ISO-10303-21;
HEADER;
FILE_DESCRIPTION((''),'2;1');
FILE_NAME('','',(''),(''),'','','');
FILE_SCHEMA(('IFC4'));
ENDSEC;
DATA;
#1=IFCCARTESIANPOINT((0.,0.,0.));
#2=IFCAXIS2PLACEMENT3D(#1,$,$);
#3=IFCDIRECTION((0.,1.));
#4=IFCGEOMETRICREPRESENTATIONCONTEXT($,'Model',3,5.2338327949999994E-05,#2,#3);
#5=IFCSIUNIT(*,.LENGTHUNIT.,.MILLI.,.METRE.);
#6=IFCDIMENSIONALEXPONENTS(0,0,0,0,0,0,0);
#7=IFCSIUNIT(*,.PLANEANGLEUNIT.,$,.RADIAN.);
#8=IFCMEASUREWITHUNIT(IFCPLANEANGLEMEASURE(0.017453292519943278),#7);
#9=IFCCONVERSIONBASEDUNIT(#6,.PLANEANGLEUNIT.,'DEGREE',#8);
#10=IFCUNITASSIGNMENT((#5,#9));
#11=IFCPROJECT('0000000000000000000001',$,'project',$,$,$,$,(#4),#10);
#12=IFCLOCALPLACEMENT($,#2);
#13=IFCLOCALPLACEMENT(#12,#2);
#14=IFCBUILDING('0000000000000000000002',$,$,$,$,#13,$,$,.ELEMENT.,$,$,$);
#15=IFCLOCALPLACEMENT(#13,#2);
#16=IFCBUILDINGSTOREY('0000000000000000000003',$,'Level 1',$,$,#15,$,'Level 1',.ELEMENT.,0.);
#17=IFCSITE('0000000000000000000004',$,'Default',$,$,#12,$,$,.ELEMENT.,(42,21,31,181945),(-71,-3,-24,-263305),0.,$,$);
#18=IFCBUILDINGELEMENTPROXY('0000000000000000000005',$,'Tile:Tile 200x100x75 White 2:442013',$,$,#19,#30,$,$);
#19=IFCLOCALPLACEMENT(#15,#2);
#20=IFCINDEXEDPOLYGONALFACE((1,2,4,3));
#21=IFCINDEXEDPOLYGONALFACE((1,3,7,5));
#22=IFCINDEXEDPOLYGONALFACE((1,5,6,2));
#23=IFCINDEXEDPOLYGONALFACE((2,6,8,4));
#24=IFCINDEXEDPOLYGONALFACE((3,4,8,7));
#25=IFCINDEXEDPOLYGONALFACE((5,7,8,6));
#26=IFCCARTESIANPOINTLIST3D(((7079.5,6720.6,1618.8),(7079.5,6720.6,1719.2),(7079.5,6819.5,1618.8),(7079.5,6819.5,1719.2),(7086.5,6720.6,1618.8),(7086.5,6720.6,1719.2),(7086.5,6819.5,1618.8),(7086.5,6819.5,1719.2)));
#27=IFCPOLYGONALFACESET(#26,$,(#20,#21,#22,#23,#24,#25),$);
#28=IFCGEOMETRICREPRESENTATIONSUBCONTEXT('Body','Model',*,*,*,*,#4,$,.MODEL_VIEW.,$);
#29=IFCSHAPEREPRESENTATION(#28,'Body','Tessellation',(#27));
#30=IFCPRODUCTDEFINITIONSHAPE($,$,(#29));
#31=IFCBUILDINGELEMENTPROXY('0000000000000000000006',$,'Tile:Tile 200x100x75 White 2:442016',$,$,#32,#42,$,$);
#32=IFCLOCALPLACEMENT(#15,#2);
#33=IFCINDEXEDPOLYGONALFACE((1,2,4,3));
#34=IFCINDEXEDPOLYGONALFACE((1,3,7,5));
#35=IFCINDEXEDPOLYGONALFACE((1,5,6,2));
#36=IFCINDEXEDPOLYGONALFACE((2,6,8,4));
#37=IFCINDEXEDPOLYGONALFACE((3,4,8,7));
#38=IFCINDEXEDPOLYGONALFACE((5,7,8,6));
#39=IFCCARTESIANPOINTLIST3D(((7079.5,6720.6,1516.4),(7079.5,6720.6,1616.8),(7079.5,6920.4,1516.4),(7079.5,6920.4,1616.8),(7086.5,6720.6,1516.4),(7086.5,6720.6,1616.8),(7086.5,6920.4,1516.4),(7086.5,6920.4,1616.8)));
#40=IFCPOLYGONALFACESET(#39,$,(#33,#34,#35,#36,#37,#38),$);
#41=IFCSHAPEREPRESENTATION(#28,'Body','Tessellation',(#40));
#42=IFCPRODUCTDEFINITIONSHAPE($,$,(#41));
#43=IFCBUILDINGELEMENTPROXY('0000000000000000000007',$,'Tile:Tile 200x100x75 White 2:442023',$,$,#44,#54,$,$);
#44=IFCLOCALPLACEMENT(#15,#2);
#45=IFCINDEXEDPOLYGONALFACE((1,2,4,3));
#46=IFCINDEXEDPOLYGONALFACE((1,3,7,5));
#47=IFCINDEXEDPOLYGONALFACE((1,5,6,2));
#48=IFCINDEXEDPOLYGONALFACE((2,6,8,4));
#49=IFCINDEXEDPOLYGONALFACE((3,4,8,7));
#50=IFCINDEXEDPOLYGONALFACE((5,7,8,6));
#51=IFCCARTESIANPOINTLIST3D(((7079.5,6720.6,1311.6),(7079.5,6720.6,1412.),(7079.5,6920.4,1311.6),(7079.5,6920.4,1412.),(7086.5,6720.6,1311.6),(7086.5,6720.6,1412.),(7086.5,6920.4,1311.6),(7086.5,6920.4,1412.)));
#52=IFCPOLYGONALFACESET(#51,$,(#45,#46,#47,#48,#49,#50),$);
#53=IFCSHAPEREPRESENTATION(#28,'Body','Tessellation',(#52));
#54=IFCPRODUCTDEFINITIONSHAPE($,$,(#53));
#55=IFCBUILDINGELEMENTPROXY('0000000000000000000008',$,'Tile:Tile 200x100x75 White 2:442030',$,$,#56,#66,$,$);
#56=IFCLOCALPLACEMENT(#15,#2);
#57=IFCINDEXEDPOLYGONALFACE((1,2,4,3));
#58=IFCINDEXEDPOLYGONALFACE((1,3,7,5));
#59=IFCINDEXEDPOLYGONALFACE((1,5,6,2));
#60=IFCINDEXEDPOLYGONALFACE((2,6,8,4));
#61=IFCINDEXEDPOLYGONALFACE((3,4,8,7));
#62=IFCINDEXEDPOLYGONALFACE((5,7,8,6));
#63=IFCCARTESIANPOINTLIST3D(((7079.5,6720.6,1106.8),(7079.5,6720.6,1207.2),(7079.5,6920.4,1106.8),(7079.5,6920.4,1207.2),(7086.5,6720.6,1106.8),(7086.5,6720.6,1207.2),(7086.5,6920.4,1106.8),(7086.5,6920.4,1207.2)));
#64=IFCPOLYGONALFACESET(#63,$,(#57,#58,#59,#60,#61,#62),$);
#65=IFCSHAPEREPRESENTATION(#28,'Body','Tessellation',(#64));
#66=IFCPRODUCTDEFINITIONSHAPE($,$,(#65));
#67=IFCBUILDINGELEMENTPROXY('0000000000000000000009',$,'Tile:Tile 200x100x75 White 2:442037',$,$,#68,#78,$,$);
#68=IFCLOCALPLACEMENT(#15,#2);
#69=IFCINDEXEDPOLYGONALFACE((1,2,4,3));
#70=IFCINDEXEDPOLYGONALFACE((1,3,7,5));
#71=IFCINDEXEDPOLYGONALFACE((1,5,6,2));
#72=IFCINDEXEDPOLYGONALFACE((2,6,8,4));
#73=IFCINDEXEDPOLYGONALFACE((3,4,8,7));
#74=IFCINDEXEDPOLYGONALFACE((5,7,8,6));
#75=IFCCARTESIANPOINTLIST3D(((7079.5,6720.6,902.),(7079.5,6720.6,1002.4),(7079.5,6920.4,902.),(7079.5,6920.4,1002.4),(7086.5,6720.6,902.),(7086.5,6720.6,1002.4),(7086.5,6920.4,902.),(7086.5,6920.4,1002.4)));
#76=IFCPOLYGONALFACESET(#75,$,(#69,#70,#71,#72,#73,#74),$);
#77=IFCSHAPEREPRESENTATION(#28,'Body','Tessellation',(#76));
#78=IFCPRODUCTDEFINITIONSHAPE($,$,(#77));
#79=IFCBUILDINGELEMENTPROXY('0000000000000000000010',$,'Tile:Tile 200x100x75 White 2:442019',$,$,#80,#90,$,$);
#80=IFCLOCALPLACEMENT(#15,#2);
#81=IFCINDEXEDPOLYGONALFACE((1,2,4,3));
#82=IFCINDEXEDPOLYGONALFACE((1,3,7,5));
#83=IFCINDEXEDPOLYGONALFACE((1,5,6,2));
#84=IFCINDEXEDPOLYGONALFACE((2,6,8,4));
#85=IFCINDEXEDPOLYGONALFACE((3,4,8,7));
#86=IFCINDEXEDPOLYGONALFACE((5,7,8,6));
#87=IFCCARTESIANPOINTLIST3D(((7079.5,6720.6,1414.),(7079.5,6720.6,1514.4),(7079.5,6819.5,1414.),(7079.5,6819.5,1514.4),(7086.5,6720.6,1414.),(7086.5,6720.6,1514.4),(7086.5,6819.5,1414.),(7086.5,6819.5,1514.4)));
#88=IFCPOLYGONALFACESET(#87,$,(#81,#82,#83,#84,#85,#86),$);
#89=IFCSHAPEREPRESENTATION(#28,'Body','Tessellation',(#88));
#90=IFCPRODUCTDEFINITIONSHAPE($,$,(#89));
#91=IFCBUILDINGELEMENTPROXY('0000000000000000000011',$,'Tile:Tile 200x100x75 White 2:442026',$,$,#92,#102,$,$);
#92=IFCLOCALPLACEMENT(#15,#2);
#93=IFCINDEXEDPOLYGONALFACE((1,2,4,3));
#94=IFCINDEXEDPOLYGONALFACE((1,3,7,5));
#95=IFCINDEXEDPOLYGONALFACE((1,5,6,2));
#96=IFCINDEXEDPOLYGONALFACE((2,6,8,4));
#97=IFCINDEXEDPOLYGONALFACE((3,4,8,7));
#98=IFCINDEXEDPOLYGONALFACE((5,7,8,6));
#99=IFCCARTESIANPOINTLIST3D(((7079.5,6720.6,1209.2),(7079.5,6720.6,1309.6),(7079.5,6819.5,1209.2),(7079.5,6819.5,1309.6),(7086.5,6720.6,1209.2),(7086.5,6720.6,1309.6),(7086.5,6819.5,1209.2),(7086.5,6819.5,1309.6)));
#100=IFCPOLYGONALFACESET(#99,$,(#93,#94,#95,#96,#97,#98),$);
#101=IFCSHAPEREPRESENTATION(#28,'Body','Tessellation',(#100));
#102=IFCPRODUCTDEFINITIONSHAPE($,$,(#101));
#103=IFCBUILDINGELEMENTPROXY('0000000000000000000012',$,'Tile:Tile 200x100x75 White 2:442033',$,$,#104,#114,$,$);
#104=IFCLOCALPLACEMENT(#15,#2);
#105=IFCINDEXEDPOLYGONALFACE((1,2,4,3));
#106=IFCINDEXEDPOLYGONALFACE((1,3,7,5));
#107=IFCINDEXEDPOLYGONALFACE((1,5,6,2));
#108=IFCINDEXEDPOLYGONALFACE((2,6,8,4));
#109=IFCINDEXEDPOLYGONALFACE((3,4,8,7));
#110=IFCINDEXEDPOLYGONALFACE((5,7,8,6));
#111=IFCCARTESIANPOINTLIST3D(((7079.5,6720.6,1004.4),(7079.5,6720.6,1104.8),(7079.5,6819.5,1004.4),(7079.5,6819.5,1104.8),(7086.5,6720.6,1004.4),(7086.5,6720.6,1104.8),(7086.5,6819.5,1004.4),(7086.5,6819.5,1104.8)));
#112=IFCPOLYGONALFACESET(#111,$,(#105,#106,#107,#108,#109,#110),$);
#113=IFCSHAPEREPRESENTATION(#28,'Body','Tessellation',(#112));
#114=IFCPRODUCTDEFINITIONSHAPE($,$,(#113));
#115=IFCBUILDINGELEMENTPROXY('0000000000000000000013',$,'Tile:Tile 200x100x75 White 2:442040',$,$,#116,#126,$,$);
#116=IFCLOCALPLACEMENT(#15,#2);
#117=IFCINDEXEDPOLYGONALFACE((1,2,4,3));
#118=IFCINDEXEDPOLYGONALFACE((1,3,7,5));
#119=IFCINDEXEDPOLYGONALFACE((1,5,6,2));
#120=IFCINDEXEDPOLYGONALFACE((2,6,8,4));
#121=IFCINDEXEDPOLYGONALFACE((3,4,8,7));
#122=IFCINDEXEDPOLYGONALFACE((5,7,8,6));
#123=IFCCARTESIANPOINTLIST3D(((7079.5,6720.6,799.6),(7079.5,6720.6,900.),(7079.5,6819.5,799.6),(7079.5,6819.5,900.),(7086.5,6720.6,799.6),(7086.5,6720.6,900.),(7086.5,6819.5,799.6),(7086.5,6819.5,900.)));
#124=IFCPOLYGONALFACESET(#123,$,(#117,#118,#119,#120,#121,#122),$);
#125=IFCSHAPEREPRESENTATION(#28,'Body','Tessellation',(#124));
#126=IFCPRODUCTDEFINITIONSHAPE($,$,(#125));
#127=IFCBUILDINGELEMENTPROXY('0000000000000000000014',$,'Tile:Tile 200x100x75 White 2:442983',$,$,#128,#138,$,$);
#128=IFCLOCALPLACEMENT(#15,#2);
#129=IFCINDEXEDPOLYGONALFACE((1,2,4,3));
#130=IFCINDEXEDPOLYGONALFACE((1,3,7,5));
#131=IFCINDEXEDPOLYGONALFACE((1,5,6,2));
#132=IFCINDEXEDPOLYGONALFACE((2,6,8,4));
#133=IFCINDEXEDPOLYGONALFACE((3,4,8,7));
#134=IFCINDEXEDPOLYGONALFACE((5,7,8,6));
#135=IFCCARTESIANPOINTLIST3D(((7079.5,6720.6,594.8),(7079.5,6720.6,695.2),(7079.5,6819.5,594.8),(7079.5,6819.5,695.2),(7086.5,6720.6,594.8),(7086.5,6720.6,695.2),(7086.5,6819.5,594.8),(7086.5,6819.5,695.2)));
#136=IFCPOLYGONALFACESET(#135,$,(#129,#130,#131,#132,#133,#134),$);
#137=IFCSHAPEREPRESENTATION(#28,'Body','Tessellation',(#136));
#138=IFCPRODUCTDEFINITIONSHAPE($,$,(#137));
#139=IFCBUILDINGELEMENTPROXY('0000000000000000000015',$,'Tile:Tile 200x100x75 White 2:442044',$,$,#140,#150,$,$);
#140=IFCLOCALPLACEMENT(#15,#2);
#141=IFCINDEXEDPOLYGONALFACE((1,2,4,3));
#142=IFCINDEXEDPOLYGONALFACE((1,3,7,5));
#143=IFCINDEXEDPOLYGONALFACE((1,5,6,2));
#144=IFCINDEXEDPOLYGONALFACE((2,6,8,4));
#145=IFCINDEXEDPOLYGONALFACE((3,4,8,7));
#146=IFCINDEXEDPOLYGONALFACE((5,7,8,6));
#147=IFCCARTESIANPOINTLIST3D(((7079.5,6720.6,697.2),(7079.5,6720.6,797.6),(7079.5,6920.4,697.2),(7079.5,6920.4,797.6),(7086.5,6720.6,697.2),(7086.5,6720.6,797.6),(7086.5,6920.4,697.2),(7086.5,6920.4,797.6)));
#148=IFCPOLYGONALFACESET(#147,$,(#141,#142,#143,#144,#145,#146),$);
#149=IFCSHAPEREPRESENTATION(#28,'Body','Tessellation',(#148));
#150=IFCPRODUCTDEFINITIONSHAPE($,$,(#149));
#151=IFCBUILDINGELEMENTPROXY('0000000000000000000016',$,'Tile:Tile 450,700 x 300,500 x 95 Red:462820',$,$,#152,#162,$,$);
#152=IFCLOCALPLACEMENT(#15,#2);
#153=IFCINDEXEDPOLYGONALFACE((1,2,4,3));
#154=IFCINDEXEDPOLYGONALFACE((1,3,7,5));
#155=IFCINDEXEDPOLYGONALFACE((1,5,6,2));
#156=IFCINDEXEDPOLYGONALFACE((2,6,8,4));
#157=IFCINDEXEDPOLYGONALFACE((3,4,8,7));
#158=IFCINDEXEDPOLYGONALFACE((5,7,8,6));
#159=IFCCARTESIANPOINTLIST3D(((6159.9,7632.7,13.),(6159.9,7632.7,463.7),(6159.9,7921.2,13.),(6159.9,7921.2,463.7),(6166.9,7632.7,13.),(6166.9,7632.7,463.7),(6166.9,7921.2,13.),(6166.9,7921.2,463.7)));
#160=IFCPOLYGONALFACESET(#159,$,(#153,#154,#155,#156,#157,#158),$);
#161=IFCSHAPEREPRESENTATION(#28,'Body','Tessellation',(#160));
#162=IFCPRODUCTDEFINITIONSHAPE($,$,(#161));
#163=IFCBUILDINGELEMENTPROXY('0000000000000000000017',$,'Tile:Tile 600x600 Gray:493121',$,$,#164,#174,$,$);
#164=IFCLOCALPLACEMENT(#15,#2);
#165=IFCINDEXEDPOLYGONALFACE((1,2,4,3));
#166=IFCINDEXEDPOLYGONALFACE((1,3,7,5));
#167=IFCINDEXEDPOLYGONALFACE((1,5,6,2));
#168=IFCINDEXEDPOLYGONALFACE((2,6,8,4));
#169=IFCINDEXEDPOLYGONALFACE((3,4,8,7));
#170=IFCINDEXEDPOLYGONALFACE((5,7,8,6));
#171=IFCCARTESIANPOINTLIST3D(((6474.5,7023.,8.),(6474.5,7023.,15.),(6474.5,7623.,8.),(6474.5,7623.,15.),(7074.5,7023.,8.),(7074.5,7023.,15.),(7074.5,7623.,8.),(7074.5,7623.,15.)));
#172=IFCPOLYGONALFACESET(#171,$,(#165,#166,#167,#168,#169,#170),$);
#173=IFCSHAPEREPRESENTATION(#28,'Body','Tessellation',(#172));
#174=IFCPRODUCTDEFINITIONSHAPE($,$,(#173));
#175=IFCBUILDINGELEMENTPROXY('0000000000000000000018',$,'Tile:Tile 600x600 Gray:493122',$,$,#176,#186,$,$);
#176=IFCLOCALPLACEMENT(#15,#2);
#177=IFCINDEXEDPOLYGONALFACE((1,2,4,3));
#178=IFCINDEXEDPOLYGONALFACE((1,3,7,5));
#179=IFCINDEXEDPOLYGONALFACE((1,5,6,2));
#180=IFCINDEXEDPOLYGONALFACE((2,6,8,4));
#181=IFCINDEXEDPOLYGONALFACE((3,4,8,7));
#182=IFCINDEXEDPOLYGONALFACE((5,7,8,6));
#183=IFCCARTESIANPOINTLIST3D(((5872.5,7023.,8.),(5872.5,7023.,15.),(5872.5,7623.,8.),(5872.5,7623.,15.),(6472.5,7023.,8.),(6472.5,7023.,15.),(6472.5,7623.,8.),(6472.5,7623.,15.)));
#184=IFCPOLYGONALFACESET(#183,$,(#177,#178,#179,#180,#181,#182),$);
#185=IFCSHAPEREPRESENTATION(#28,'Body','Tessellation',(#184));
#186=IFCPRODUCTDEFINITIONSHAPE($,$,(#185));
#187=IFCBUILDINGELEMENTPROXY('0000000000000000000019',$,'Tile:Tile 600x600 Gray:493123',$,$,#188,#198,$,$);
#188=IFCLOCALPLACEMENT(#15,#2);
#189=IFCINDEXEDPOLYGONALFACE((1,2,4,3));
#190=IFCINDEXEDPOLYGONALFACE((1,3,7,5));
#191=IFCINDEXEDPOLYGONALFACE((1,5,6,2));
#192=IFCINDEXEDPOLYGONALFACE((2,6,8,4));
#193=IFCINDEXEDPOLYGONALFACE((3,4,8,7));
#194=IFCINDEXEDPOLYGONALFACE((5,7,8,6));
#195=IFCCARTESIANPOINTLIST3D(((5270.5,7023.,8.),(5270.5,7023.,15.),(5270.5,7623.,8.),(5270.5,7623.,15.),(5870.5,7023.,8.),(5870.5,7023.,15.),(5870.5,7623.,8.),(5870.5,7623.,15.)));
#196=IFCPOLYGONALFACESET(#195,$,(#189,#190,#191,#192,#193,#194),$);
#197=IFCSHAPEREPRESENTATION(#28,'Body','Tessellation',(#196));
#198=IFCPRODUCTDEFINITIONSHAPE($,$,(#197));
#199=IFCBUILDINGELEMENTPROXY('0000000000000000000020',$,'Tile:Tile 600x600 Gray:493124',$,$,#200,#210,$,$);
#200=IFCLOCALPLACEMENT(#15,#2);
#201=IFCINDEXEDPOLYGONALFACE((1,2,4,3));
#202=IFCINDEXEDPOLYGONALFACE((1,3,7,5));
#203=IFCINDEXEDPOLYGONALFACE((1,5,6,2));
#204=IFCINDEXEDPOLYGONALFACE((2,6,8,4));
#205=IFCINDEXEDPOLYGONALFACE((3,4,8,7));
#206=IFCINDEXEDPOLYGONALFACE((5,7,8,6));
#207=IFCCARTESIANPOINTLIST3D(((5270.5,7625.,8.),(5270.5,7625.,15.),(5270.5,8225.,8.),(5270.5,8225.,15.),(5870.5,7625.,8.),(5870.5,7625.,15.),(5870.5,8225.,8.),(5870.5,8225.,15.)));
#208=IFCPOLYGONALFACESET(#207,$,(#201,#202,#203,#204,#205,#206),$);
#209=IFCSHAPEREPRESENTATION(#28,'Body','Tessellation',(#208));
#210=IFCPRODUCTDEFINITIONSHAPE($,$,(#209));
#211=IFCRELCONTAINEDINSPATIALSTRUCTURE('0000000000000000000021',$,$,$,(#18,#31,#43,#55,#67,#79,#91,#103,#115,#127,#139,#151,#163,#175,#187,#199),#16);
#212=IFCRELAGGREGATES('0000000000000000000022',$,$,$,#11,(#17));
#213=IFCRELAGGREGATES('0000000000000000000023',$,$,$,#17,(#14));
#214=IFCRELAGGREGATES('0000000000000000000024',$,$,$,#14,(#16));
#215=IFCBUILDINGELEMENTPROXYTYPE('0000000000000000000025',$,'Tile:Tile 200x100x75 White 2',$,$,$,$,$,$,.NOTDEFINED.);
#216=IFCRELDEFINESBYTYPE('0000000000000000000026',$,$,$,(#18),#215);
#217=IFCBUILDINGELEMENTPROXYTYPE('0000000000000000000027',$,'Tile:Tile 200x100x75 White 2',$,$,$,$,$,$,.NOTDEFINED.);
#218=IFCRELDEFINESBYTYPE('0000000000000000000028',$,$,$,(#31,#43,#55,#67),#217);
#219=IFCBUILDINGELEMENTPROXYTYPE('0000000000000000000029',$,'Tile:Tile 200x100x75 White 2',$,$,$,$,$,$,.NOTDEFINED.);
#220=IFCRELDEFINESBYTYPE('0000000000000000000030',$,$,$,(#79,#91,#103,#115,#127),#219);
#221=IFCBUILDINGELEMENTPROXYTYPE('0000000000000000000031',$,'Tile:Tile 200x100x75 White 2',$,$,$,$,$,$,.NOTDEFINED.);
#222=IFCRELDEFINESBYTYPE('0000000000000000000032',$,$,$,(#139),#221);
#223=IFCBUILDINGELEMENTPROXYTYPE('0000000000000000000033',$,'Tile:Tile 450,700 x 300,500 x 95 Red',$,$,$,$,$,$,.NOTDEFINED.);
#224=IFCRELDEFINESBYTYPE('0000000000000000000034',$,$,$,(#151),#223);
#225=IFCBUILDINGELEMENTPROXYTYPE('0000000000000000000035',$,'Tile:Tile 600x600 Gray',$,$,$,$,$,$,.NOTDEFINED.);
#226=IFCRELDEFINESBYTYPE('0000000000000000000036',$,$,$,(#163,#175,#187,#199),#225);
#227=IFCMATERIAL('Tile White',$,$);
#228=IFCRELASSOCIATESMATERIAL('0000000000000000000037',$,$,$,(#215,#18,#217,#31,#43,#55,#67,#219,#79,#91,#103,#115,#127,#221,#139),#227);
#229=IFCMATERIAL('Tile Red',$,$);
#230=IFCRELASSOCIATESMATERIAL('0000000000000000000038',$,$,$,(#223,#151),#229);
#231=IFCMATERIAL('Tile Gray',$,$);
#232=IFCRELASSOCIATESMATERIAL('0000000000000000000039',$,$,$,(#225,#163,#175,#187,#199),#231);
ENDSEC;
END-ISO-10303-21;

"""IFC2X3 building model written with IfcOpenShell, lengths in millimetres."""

from ifc_helpers import new_model, entity, si_unit, converted_unit, direction, frame, frame_2d, origin, origin_2d_with_axis, place, context, subcontext, project, spatial, rectangle, extrude, source, transform, mapped, material, type_object, type_shapes, element, save


model = new_model("IFC2X3")

# Units and contexts
model_context = context("Model", 3, precision=5.2338327949999994e-05, world=origin(), true_north=direction((0.0, 1.0)))
body_context = subcontext(model_context, "Body", "Model", "MODEL_VIEW")
ifc_project = project(units=[si_unit("LENGTHUNIT", "METRE", prefix="MILLI"), converted_unit("PLANEANGLEUNIT", "DEGREE", entity("IfcPlaneAngleMeasure", 0.017453292519943278), si_unit("PLANEANGLEUNIT", "RADIAN"), dimensions=[0, 0, 0, 0, 0, 0, 0])], contexts=[model_context])

# Site, building, storey
site_placement = place(None, origin())
site = spatial("IfcSite", under=ifc_project, at=site_placement, Name="Default", CompositionType="ELEMENT", RefLatitude=(42, 21, 31, 181945), RefLongitude=(-71, -3, -24, -263305), RefElevation=0.0)
building_placement = place(site_placement, origin())
building = spatial("IfcBuilding", under=site, at=building_placement, CompositionType="ELEMENT")
storey_placement = place(building_placement, origin())
storey = spatial("IfcBuildingStorey", under=building, at=storey_placement, Name="Level 1", LongName="Level 1", CompositionType="ELEMENT", Elevation=0.0)

# Building element proxies
ifc_material_1 = material(Name="Tile White")
building_element_proxy_type_1 = type_object("IfcBuildingElementProxyType", Name="Tile:Tile 200x100x75 White 2", PredefinedType="NOTDEFINED", material=ifc_material_1)
shared_shape_1 = source(origin(), body_context, "Body", "SweptSolid", [
    extrude(rectangle(XDim=100.4, YDim=98.9, at=origin_2d_with_axis()), frame((-50.2, 49.5, 0.0)), (0.0, 0.0, 1.0), 7.0),
])
type_shapes(building_element_proxy_type_1, [shared_shape_1])
proxy_1_placement = place(storey_placement, frame((7086.5, 6720.6, 1719.2), z_axis=(-1.0, 0.0, 0.0), x_axis=(0.0, 0.0, 1.0)))
element("IfcBuildingElementProxy", 1, at=proxy_1_placement, inside=storey, type_object=building_element_proxy_type_1, material=ifc_material_1, Name="Tile:Tile 200x100x75 White 2:442013", context=body_context, shape_type="MappedRepresentation", body=[
    mapped(shared_shape_1, transform((0.0, 0.0, 0.0), scale=1.0)),
])
building_element_proxy_type_2 = type_object("IfcBuildingElementProxyType", Name="Tile:Tile 200x100x75 White 2", PredefinedType="NOTDEFINED", material=ifc_material_1)
shared_shape_2 = source(origin(), body_context, "Body", "SweptSolid", [
    extrude(rectangle(XDim=100.4, YDim=199.8, at=origin_2d_with_axis()), frame((-50.2, 99.9, 0.0)), (0.0, 0.0, 1.0), 7.0),
])
type_shapes(building_element_proxy_type_2, [shared_shape_2])
for number, where, z_axis, x_axis, name in (
    (2, (7086.5, 6720.6, 1616.8), (-1.0, 0.0, 0.0), (0.0, 0.0, 1.0), "Tile:Tile 200x100x75 White 2:442016"),
    (3, (7086.5, 6720.6, 1412.0), (-1.0, 0.0, 0.0), (0.0, 0.0, 1.0), "Tile:Tile 200x100x75 White 2:442023"),
    (4, (7086.5, 6720.6, 1207.2), (-1.0, 0.0, 0.0), (0.0, 0.0, 1.0), "Tile:Tile 200x100x75 White 2:442030"),
    (5, (7086.5, 6720.6, 1002.4), (-1.0, 0.0, 0.0), (0.0, 0.0, 1.0), "Tile:Tile 200x100x75 White 2:442037"),
):
    element("IfcBuildingElementProxy", number, at=place(storey_placement, frame(where, z_axis=z_axis, x_axis=x_axis)), inside=storey, type_object=building_element_proxy_type_2, material=ifc_material_1, Name=name, context=body_context, shape_type="MappedRepresentation", body=[
        mapped(shared_shape_2, transform((0.0, 0.0, 0.0), scale=1.0)),
    ])
building_element_proxy_type_3 = type_object("IfcBuildingElementProxyType", Name="Tile:Tile 200x100x75 White 2", PredefinedType="NOTDEFINED", material=ifc_material_1)
shared_shape_3 = source(origin(), body_context, "Body", "SweptSolid", [
    extrude(rectangle(XDim=100.4, YDim=98.9, at=origin_2d_with_axis()), frame((-50.2, 49.5, 0.0)), (0.0, 0.0, 1.0), 7.0),
])
type_shapes(building_element_proxy_type_3, [shared_shape_3])
for number, where, z_axis, x_axis, name in (
    (6, (7086.5, 6720.6, 1514.4), (-1.0, 0.0, 0.0), (0.0, 0.0, 1.0), "Tile:Tile 200x100x75 White 2:442019"),
    (7, (7086.5, 6720.6, 1309.6), (-1.0, 0.0, 0.0), (0.0, 0.0, 1.0), "Tile:Tile 200x100x75 White 2:442026"),
    (8, (7086.5, 6720.6, 1104.8), (-1.0, 0.0, 0.0), (0.0, 0.0, 1.0), "Tile:Tile 200x100x75 White 2:442033"),
    (9, (7086.5, 6720.6, 900.0), (-1.0, 0.0, 0.0), (0.0, 0.0, 1.0), "Tile:Tile 200x100x75 White 2:442040"),
    (10, (7086.5, 6720.6, 695.2), (-1.0, 0.0, 0.0), (0.0, 0.0, 1.0), "Tile:Tile 200x100x75 White 2:442983"),
):
    element("IfcBuildingElementProxy", number, at=place(storey_placement, frame(where, z_axis=z_axis, x_axis=x_axis)), inside=storey, type_object=building_element_proxy_type_3, material=ifc_material_1, Name=name, context=body_context, shape_type="MappedRepresentation", body=[
        mapped(shared_shape_3, transform((0.0, 0.0, 0.0), scale=1.0)),
    ])
building_element_proxy_type_4 = type_object("IfcBuildingElementProxyType", Name="Tile:Tile 200x100x75 White 2", PredefinedType="NOTDEFINED", material=ifc_material_1)
shared_shape_4 = source(origin(), body_context, "Body", "SweptSolid", [
    extrude(rectangle(XDim=100.4, YDim=199.8, at=origin_2d_with_axis()), frame((-50.2, 99.9, 0.0)), (0.0, 0.0, 1.0), 7.0),
])
type_shapes(building_element_proxy_type_4, [shared_shape_4])
proxy_2_placement = place(storey_placement, frame((7086.5, 6720.6, 797.6), z_axis=(-1.0, 0.0, 0.0), x_axis=(0.0, 0.0, 1.0)))
element("IfcBuildingElementProxy", 11, at=proxy_2_placement, inside=storey, type_object=building_element_proxy_type_4, material=ifc_material_1, Name="Tile:Tile 200x100x75 White 2:442044", context=body_context, shape_type="MappedRepresentation", body=[
    mapped(shared_shape_4, transform((0.0, 0.0, 0.0), scale=1.0)),
])
ifc_material_2 = material(Name="Tile Red")
building_element_proxy_type_5 = type_object("IfcBuildingElementProxyType", Name="Tile:Tile 450,700 x 300,500 x 95 Red", PredefinedType="NOTDEFINED", material=ifc_material_2)
shared_shape_5 = source(origin(), body_context, "Body", "SweptSolid", [
    extrude(rectangle(XDim=450.7, YDim=288.5, at=origin_2d_with_axis()), frame((-144.2, 225.4, 0.0), z_axis=(0.0, 0.0, 1.0), x_axis=(0.0, 1.0, 0.0)), (0.0, 0.0, 1.0), 7.0),
])
type_shapes(building_element_proxy_type_5, [shared_shape_5])
proxy_3_placement = place(storey_placement, frame((6166.9, 7632.7, 13.0), z_axis=(-1.0, 0.0, 0.0), x_axis=(0.0, -1.0, 0.0)))
element("IfcBuildingElementProxy", 12, at=proxy_3_placement, inside=storey, type_object=building_element_proxy_type_5, material=ifc_material_2, Name="Tile:Tile 450,700 x 300,500 x 95 Red:462820", context=body_context, shape_type="MappedRepresentation", body=[
    mapped(shared_shape_5, transform((0.0, 0.0, 0.0), scale=1.0)),
])
ifc_material_3 = material(Name="Tile Gray")
building_element_proxy_type_6 = type_object("IfcBuildingElementProxyType", Name="Tile:Tile 600x600 Gray", PredefinedType="NOTDEFINED", material=ifc_material_3)
shared_shape_6 = source(origin(), body_context, "Body", "SweptSolid", [
    extrude(rectangle(XDim=600.0, YDim=600.0, at=frame_2d((0.0, 0.0), x_axis=(1.0, 0.0))), frame((-300.0, -300.0, 0.0), z_axis=(0.0, 0.0, 1.0), x_axis=(0.0, -1.0, 0.0)), (0.0, 0.0, 1.0), 7.0),
])
type_shapes(building_element_proxy_type_6, [shared_shape_6])
for number, where, z_axis, x_axis, name in (
    (13, (7074.5, 7023.0, 8.0), (0.0, 0.0, 1.0), (0.0, -1.0, 0.0), "Tile:Tile 600x600 Gray:493121"),
    (14, (6472.5, 7023.0, 8.0), (0.0, 0.0, 1.0), (0.0, -1.0, 0.0), "Tile:Tile 600x600 Gray:493122"),
    (15, (5870.5, 7023.0, 8.0), (0.0, 0.0, 1.0), (0.0, -1.0, 0.0), "Tile:Tile 600x600 Gray:493123"),
    (16, (5870.5, 7625.0, 8.0), (0.0, 0.0, 1.0), (0.0, -1.0, 0.0), "Tile:Tile 600x600 Gray:493124"),
):
    element("IfcBuildingElementProxy", number, at=place(storey_placement, frame(where, z_axis=z_axis, x_axis=x_axis)), inside=storey, type_object=building_element_proxy_type_6, material=ifc_material_3, Name=name, context=body_context, shape_type="MappedRepresentation", body=[
        mapped(shared_shape_6, transform((0.0, 0.0, 0.0), scale=1.0)),
    ])

save(model, "model.ifc")
